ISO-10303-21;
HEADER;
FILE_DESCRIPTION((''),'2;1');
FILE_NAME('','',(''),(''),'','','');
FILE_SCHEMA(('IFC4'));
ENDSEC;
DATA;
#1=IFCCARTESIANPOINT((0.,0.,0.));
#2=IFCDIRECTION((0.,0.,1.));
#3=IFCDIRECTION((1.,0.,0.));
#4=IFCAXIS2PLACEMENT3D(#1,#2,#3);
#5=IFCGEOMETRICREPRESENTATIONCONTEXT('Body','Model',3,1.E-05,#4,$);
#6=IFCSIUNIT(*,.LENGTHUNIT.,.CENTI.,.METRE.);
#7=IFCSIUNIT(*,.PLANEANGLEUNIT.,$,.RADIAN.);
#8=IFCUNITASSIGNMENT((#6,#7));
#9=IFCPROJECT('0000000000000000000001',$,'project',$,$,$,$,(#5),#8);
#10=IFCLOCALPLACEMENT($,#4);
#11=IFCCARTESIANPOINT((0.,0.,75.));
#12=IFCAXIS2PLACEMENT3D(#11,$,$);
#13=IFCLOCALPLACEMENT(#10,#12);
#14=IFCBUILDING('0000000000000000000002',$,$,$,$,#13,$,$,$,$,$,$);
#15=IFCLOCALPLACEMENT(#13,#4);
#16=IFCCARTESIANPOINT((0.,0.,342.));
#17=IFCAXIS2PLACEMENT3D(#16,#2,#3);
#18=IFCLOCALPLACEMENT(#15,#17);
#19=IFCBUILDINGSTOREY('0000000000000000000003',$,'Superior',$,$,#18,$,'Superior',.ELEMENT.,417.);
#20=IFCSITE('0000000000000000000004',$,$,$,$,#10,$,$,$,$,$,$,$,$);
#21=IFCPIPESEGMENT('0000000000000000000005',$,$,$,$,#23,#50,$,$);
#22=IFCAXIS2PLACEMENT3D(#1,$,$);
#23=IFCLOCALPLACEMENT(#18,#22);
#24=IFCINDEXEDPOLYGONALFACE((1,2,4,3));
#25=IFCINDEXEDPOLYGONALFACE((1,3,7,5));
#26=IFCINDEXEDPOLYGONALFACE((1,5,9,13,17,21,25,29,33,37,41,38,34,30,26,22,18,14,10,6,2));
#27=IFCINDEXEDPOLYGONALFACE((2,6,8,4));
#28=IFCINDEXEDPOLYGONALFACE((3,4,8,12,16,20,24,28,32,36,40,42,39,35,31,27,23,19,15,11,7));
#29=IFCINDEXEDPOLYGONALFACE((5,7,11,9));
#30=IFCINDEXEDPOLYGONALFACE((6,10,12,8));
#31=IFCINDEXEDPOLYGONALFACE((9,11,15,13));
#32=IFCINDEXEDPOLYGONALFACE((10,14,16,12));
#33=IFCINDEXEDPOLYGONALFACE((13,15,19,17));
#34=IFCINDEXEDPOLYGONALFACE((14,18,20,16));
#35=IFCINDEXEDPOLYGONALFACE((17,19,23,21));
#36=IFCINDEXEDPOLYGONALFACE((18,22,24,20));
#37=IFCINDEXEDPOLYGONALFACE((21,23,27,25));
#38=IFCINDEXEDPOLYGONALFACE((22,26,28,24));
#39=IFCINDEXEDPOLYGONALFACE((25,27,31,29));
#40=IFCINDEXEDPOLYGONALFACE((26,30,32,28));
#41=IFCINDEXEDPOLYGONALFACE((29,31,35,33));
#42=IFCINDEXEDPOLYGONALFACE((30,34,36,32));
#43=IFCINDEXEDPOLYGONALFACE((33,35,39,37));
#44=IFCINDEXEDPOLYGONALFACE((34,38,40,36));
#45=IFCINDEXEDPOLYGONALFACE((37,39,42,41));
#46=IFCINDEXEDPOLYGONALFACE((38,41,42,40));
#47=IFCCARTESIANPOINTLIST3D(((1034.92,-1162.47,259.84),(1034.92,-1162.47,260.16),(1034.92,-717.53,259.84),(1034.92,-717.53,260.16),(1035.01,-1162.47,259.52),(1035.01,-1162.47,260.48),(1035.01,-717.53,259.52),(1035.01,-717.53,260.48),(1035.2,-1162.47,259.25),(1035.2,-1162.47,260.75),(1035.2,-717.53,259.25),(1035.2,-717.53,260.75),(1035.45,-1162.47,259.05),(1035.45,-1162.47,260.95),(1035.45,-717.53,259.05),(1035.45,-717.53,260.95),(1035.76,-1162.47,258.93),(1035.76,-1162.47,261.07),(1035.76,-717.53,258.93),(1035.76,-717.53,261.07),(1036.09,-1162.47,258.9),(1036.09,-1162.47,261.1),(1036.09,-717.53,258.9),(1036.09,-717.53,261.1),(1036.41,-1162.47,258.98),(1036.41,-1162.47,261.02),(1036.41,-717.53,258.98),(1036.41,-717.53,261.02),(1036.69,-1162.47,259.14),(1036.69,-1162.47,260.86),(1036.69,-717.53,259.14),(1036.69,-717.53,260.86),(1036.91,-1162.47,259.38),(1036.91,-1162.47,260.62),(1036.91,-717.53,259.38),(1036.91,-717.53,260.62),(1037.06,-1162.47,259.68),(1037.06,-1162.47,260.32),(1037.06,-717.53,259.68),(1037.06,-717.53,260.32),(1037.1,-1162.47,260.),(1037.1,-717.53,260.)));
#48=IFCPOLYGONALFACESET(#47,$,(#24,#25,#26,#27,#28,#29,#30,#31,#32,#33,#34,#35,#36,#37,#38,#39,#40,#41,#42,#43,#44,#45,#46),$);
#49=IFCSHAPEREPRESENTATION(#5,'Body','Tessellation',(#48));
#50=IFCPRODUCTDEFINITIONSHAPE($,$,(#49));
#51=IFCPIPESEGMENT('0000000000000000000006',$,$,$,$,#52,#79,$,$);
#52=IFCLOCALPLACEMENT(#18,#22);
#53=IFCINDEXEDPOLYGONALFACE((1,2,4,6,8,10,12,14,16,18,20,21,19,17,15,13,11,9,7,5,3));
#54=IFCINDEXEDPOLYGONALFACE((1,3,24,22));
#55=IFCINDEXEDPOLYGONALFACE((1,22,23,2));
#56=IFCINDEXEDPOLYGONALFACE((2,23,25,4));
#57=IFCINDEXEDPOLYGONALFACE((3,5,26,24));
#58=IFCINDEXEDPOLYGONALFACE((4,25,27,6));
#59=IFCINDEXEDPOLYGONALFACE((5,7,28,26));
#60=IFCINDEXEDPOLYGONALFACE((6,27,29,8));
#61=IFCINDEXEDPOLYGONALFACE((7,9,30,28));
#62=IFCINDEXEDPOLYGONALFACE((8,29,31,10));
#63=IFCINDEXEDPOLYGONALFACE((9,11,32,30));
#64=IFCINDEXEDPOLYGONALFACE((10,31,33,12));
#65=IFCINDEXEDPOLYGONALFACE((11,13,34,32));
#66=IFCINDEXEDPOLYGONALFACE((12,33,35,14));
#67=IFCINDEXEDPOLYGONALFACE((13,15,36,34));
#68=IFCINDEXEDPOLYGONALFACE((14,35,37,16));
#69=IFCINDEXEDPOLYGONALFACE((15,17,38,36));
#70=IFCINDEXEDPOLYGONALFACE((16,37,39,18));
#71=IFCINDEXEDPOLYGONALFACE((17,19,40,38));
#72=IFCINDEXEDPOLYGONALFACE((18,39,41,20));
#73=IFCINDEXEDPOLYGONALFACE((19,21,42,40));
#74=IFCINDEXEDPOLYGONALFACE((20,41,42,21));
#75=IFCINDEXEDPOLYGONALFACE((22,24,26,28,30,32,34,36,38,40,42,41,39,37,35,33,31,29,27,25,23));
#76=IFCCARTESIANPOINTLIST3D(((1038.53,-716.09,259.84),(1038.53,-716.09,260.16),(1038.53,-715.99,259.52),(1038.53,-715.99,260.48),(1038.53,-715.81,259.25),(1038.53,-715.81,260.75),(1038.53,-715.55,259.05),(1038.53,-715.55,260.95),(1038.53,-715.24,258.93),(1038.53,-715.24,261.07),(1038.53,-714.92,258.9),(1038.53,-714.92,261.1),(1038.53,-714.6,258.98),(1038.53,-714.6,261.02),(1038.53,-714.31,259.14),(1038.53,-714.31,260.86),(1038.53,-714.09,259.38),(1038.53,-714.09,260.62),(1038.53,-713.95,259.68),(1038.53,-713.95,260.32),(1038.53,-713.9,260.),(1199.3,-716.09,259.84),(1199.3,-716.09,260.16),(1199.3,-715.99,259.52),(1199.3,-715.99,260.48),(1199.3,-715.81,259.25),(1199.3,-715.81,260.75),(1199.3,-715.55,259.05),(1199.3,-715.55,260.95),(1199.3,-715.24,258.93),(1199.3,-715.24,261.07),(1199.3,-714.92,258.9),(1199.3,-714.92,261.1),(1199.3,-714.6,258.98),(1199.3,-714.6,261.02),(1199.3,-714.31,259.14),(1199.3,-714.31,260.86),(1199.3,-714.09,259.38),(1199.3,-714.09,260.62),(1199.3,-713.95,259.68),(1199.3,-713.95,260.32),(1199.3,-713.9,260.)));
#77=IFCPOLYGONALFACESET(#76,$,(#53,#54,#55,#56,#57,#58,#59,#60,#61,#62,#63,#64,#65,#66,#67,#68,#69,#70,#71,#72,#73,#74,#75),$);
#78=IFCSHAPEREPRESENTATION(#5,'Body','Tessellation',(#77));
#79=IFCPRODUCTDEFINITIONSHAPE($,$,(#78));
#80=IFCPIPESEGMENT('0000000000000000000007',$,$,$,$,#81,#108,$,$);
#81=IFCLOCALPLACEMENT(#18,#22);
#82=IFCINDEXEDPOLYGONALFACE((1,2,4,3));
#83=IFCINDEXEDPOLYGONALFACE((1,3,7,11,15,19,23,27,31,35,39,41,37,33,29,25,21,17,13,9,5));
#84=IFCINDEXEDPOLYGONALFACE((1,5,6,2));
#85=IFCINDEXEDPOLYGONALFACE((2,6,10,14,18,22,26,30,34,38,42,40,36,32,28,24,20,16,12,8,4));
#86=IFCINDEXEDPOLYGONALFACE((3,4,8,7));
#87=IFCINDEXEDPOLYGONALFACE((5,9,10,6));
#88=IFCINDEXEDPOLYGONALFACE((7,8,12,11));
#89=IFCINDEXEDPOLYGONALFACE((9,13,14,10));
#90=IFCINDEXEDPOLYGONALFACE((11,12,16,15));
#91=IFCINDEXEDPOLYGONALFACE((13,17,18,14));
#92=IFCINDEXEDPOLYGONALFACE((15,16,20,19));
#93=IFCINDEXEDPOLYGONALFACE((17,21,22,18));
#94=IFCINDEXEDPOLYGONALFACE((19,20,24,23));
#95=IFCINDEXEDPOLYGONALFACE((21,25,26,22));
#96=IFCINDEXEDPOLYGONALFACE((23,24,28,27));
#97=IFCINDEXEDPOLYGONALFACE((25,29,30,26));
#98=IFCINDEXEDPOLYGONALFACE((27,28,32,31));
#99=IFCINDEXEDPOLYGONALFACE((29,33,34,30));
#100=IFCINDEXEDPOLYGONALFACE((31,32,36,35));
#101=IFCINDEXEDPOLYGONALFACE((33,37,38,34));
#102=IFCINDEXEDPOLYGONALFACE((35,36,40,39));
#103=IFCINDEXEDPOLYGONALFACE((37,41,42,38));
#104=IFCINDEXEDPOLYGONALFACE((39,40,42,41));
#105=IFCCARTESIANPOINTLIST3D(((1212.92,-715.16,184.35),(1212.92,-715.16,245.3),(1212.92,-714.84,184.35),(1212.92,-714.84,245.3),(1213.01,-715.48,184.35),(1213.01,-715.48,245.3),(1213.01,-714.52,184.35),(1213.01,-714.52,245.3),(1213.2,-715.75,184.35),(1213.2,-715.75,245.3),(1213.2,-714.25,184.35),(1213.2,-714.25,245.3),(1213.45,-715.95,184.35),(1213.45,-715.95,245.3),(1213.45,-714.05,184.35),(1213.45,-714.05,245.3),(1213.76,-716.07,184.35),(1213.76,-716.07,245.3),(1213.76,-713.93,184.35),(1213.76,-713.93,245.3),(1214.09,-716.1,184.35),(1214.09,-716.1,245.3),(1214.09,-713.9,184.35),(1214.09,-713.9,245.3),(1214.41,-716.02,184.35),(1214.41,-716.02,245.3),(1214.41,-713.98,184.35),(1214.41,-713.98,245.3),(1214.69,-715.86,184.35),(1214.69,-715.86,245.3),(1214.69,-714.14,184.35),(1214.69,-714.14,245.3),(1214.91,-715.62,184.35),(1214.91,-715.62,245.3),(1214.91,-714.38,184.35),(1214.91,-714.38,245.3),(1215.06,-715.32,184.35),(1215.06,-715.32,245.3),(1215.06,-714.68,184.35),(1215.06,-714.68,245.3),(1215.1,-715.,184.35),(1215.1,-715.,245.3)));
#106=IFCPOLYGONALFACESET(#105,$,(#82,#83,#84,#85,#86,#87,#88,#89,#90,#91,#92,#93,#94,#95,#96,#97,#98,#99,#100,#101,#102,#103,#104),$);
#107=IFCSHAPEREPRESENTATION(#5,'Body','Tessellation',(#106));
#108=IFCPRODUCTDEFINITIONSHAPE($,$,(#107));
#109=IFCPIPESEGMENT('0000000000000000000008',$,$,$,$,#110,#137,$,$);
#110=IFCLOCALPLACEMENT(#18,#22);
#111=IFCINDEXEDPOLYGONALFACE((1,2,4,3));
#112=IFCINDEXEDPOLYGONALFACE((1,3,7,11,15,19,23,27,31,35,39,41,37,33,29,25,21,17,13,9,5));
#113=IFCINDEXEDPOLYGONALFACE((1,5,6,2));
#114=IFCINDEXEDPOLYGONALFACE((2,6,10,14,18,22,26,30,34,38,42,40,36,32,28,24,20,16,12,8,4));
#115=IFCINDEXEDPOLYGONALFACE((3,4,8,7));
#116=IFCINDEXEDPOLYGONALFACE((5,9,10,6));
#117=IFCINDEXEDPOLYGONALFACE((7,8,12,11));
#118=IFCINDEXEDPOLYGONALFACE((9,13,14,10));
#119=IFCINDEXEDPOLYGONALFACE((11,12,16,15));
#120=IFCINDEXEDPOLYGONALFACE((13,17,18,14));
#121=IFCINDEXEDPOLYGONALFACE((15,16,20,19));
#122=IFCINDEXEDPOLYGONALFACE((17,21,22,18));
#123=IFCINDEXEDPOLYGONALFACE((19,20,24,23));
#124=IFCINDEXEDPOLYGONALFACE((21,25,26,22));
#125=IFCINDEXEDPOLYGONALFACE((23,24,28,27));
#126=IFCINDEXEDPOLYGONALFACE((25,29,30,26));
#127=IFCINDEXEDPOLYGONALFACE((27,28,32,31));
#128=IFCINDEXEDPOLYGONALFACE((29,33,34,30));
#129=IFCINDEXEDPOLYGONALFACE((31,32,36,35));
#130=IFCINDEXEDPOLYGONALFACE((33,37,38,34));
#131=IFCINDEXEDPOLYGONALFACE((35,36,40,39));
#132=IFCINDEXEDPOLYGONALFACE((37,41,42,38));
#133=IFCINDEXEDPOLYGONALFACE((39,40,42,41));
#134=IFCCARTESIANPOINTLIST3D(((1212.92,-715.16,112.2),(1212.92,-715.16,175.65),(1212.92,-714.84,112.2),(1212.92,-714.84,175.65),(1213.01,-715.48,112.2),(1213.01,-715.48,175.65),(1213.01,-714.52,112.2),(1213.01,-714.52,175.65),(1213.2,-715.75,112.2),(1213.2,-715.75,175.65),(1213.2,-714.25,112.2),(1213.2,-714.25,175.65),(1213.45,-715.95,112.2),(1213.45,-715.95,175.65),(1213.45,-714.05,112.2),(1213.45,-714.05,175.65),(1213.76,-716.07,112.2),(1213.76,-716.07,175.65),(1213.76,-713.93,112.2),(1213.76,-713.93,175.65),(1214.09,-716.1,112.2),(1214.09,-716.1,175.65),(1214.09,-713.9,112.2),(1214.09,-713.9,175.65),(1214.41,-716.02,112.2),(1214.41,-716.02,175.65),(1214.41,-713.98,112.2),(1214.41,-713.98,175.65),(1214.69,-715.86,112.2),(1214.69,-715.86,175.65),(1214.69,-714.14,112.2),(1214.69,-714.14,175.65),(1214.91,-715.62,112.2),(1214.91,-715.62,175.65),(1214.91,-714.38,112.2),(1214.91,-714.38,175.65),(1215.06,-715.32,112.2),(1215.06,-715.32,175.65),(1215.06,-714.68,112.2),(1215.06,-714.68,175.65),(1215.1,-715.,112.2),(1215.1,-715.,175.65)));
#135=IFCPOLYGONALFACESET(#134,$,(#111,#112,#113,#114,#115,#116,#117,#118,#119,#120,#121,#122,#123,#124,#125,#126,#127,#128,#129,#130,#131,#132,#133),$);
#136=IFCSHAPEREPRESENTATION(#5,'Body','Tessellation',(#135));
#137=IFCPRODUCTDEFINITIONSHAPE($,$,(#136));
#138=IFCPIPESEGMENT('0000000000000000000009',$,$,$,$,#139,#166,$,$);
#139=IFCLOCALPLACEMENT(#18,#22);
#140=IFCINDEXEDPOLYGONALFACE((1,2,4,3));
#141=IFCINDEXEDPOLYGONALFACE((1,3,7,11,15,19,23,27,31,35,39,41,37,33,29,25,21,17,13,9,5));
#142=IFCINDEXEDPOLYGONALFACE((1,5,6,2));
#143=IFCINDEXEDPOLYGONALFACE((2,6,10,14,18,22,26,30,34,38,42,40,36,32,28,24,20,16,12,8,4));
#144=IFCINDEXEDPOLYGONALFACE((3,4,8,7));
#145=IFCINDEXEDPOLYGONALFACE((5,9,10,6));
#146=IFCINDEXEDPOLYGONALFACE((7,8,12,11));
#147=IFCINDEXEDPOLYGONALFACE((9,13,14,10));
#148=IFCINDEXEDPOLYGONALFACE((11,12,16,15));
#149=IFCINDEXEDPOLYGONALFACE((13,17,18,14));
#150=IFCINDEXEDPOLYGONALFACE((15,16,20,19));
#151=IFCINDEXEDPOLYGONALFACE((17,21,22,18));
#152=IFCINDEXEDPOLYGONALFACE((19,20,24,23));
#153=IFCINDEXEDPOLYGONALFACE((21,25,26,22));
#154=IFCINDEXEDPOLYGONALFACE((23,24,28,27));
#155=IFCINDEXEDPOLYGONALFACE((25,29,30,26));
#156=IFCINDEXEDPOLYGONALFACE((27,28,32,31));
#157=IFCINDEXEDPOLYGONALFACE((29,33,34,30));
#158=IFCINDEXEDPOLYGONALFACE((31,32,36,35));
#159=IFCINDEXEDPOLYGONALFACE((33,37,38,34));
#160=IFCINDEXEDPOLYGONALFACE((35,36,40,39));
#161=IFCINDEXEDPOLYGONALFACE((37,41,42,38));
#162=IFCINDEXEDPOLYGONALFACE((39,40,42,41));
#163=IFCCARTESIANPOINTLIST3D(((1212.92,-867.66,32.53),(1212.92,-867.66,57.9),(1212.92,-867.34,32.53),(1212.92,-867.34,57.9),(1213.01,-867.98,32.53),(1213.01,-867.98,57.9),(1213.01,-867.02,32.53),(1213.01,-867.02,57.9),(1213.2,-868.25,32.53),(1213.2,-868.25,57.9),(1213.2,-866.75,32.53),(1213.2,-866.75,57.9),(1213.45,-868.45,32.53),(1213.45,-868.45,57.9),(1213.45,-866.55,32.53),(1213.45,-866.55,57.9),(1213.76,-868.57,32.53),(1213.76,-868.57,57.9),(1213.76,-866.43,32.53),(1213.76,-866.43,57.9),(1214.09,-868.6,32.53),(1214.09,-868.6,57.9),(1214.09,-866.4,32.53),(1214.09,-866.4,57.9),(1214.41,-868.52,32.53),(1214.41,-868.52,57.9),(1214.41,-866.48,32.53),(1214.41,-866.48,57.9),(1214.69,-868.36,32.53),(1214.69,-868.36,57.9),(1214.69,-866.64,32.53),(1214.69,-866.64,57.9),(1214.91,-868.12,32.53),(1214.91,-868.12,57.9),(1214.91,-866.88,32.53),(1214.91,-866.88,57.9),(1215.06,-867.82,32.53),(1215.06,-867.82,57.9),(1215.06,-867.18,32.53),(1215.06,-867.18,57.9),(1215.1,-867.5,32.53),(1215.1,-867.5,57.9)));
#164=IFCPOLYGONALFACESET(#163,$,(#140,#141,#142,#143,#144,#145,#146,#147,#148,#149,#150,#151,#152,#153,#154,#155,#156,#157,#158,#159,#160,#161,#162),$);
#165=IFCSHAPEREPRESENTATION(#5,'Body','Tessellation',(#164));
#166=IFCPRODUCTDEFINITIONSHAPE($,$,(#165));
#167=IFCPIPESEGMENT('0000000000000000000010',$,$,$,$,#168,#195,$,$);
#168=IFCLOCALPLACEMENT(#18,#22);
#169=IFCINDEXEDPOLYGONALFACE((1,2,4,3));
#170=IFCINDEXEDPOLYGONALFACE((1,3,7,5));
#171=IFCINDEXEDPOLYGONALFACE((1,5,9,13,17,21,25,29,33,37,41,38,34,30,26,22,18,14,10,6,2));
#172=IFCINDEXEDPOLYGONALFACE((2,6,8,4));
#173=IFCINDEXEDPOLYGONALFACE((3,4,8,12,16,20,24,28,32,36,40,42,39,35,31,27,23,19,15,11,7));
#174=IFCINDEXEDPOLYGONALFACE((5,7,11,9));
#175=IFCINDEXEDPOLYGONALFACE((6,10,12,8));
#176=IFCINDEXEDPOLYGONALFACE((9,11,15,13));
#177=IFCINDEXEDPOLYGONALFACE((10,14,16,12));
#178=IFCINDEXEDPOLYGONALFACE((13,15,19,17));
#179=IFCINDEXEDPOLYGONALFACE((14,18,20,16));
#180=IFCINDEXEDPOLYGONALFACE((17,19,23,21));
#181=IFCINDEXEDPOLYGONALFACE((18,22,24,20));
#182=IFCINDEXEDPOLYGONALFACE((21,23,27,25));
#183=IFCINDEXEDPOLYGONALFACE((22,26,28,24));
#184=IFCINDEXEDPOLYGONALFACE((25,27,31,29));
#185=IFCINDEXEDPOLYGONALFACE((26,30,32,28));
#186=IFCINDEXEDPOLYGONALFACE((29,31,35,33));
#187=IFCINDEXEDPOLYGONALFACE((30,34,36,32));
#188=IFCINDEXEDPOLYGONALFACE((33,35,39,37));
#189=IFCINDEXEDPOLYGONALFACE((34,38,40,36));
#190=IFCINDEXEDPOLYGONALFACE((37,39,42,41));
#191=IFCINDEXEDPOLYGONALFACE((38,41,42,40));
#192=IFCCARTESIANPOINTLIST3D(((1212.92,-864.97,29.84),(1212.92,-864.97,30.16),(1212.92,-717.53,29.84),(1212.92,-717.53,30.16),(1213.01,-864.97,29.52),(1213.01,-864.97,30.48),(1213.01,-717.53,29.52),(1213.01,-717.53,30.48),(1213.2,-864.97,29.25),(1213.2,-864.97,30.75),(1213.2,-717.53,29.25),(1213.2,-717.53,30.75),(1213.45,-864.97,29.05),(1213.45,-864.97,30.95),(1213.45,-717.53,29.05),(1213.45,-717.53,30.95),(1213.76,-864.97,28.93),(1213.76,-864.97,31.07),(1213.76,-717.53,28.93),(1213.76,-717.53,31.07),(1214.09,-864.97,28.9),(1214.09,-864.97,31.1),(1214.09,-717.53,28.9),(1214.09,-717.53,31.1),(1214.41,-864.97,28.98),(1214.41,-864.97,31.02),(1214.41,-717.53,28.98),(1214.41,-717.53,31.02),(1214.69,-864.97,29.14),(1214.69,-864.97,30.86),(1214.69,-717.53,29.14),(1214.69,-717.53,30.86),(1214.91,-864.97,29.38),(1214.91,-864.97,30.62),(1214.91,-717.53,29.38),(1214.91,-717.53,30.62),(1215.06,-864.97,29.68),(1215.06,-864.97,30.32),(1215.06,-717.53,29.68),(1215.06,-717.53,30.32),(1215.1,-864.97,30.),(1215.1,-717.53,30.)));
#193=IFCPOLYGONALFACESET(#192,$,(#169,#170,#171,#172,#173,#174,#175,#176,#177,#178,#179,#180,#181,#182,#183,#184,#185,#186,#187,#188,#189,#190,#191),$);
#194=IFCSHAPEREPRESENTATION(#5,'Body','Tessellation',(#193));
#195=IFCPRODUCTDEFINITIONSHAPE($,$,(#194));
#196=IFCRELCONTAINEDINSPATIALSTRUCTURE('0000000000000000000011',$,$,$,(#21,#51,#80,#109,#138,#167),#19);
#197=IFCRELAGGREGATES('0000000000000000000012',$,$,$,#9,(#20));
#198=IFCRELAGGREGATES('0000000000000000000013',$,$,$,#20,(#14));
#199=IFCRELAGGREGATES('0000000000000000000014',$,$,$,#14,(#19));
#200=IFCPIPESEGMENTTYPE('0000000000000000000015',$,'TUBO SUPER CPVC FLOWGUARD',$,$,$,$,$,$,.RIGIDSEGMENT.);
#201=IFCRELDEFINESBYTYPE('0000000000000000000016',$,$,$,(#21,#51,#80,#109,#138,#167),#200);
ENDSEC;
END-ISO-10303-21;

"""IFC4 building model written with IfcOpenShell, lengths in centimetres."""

from ifc_helpers import new_model, si_unit, frame, origin_with_axes, origin_2d_with_axis, place, context, project, spatial, circle, extrude, type_object, element, save


model = new_model("IFC4")

# Units and contexts
model_context = context("Model", 3, precision=1e-05, world=origin_with_axes(), identifier="Body")
ifc_project = project(units=[si_unit("LENGTHUNIT", "METRE", prefix="CENTI"), si_unit("PLANEANGLEUNIT", "RADIAN")], contexts=[model_context])

# Site, building, storey
site_placement = place(None, origin_with_axes())
site = spatial("IfcSite", under=ifc_project, at=site_placement)
building_placement = place(site_placement, frame((0.0, 0.0, 75.0)))
building = spatial("IfcBuilding", under=site, at=building_placement)
placement = place(building_placement, origin_with_axes())
storey_placement = place(placement, frame((0.0, 0.0, 342.0), z_axis=(0.0, 0.0, 1.0), x_axis=(1.0, 0.0, 0.0)))
storey = spatial("IfcBuildingStorey", under=building, at=storey_placement, Name="Superior", LongName="Superior", CompositionType="ELEMENT", Elevation=417.0)

# Pipe segments
pipe_segment_type_1 = type_object("IfcPipeSegmentType", Name="TUBO SUPER CPVC FLOWGUARD", PredefinedType="RIGIDSEGMENT")
pipe_segment_1_placement = place(storey_placement, frame((1036.0, -940.0, 261.1), z_axis=(0.0, 0.0, 1.0), x_axis=(1.0, 0.0, 0.0)))
element("IfcPipeSegment", 1, at=pipe_segment_1_placement, inside=storey, type_object=pipe_segment_type_1, context=model_context, shape_type="SolidModel", body=[
    extrude(circle(Radius=1.1, at=origin_2d_with_axis()), frame((0.0, -222.47, -1.1), z_axis=(0.0, 1.0, 0.0), x_axis=(1.0, 0.0, 0.0)), (0.0, 0.0, 1.0), 444.94),
])
pipe_segment_2_placement = place(storey_placement, frame((1118.92, -715.0, 261.1), z_axis=(0.0, 0.0, 1.0), x_axis=(1.0, 0.0, 0.0)))
element("IfcPipeSegment", 2, at=pipe_segment_2_placement, inside=storey, type_object=pipe_segment_type_1, context=model_context, shape_type="SolidModel", body=[
    extrude(circle(Radius=1.1, at=origin_2d_with_axis()), frame((-80.39, 0.0, -1.1), z_axis=(1.0, 0.0, 0.0), x_axis=(0.0, 1.0, 0.0)), (0.0, 0.0, 1.0), 160.77),
])
pipe_segment_3_placement = place(storey_placement, frame((1214.0, -715.0, 245.3), z_axis=(0.0, 0.0, 1.0), x_axis=(1.0, 0.0, 0.0)))
element("IfcPipeSegment", 3, at=pipe_segment_3_placement, inside=storey, type_object=pipe_segment_type_1, context=model_context, shape_type="SolidModel", body=[
    extrude(circle(Radius=1.1, at=origin_2d_with_axis()), frame((0.0, 0.0, 0.0), z_axis=(0.0, 0.0, -1.0), x_axis=(1.0, 0.0, 0.0)), (0.0, 0.0, 1.0), 60.95),
])
pipe_segment_4_placement = place(storey_placement, frame((1214.0, -715.0, 175.65), z_axis=(0.0, 0.0, 1.0), x_axis=(1.0, 0.0, 0.0)))
element("IfcPipeSegment", 4, at=pipe_segment_4_placement, inside=storey, type_object=pipe_segment_type_1, context=model_context, shape_type="SolidModel", body=[
    extrude(circle(Radius=1.1, at=origin_2d_with_axis()), frame((0.0, 0.0, 0.0), z_axis=(0.0, 0.0, -1.0), x_axis=(1.0, 0.0, 0.0)), (0.0, 0.0, 1.0), 63.45),
])
pipe_segment_5_placement = place(storey_placement, frame((1214.0, -867.5, 57.9), z_axis=(0.0, 0.0, 1.0), x_axis=(1.0, 0.0, 0.0)))
element("IfcPipeSegment", 5, at=pipe_segment_5_placement, inside=storey, type_object=pipe_segment_type_1, context=model_context, shape_type="SolidModel", body=[
    extrude(circle(Radius=1.1, at=origin_2d_with_axis()), frame((0.0, 0.0, -25.37), z_axis=(0.0, 0.0, 1.0), x_axis=(1.0, 0.0, 0.0)), (0.0, 0.0, 1.0), 25.37),
])
pipe_segment_6_placement = place(storey_placement, frame((1214.0, -791.25, 31.1), z_axis=(0.0, 0.0, 1.0), x_axis=(1.0, 0.0, 0.0)))
element("IfcPipeSegment", 6, at=pipe_segment_6_placement, inside=storey, type_object=pipe_segment_type_1, context=model_context, shape_type="SolidModel", body=[
    extrude(circle(Radius=1.1, at=origin_2d_with_axis()), frame((0.0, 73.72, -1.1), z_axis=(0.0, -1.0, 0.0), x_axis=(1.0, 0.0, 0.0)), (0.0, 0.0, 1.0), 147.44),
])

save(model, "model.ifc")
